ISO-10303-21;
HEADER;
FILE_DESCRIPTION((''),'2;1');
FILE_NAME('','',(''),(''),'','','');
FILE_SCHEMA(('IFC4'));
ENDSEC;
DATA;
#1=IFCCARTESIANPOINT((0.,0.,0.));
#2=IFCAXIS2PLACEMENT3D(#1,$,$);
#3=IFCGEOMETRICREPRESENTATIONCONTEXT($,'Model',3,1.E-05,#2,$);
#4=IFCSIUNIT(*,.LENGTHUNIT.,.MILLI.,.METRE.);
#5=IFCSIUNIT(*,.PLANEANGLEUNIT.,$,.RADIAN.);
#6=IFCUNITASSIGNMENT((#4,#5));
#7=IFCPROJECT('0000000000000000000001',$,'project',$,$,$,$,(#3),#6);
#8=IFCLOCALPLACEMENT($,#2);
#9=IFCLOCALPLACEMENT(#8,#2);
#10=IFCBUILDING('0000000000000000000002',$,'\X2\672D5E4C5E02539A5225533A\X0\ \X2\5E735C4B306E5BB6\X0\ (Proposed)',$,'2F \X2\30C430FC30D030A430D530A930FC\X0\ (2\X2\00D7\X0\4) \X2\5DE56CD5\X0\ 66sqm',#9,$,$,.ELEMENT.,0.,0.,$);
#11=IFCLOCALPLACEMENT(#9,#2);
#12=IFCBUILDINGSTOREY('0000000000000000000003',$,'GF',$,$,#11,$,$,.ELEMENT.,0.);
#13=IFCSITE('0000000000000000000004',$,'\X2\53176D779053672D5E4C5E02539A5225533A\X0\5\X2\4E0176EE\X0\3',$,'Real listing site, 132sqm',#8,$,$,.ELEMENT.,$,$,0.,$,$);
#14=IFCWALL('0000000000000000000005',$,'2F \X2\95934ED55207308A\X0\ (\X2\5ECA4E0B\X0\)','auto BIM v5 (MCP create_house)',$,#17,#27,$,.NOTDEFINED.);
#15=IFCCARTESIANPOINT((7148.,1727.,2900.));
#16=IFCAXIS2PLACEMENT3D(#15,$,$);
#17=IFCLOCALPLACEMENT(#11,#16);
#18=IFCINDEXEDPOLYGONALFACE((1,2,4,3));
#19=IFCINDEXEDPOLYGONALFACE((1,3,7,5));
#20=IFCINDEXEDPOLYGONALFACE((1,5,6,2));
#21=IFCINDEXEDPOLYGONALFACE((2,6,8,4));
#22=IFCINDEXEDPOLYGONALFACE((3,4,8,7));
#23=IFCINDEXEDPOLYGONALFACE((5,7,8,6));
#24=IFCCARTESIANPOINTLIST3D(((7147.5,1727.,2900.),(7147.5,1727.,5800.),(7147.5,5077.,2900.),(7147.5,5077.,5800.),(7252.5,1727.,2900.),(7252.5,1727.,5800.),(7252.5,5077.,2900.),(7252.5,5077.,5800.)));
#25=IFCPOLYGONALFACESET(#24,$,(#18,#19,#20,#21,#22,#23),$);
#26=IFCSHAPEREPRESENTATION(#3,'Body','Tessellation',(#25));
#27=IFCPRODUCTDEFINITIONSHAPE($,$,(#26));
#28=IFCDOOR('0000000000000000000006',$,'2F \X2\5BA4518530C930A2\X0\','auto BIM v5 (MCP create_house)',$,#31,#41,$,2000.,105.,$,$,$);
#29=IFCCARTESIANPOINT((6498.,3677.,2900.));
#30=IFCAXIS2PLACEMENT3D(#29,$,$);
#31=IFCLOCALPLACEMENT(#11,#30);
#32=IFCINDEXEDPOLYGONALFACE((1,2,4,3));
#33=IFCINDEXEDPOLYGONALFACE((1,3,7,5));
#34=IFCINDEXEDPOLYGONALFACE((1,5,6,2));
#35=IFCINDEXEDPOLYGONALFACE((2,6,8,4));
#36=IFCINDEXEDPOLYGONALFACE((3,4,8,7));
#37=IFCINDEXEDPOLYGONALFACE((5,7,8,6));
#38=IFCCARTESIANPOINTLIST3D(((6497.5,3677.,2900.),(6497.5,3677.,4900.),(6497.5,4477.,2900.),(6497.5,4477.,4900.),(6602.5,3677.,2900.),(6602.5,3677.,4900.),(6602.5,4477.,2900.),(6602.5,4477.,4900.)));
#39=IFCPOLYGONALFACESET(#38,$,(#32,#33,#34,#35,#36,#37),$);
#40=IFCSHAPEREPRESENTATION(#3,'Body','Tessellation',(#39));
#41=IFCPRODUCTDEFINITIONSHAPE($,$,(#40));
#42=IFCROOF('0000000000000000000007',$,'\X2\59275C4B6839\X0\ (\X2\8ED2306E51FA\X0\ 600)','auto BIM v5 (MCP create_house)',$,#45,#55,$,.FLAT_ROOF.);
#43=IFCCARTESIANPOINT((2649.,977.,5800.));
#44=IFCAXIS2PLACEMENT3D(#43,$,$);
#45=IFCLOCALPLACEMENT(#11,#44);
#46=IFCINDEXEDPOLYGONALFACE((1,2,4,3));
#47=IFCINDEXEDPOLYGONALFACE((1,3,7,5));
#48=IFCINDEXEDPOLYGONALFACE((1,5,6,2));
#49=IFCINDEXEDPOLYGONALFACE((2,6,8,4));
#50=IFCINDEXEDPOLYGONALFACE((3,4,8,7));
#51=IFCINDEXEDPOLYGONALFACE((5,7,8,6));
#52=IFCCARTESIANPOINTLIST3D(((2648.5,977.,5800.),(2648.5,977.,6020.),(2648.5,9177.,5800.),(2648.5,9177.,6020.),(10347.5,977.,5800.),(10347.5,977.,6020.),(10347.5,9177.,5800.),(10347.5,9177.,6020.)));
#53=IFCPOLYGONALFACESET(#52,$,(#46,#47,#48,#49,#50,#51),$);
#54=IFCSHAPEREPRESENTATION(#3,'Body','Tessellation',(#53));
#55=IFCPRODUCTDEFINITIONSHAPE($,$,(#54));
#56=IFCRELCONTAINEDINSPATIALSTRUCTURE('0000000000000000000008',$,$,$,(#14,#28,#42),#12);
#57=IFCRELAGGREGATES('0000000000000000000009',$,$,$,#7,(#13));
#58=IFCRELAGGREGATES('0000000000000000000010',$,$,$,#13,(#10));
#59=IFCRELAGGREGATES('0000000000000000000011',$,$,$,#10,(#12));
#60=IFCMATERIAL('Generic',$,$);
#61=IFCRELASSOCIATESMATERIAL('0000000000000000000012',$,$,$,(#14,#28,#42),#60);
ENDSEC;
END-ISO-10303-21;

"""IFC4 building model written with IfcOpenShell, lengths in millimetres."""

from ifc_helpers import new_model, si_unit, frame, frame_2d, origin, place, context, project, spatial, rectangle, extrude, material, element, save


model = new_model("IFC4")

# Units and contexts
model_context = context("Model", 3, precision=1e-05, world=origin())
ifc_project = project(units=[si_unit("LENGTHUNIT", "METRE", prefix="MILLI"), si_unit("PLANEANGLEUNIT", "RADIAN")], contexts=[model_context])

# Site, building, storey
site_placement = place(None, origin())
site = spatial("IfcSite", under=ifc_project, at=site_placement, Name="北海道札幌市厚別区5丁目3", ObjectType="Real listing site, 132sqm", CompositionType="ELEMENT", RefElevation=0.0)
building_placement = place(site_placement, origin())
building = spatial("IfcBuilding", under=site, at=building_placement, Name="札幌市厚別区 平屋の家 (Proposed)", ObjectType="2F ツーバイフォー (2×4) 工法 66sqm", CompositionType="ELEMENT", ElevationOfRefHeight=0.0, ElevationOfTerrain=0.0)
storey_placement = place(building_placement, origin())
storey = spatial("IfcBuildingStorey", under=building, at=storey_placement, Name="GF", CompositionType="ELEMENT", Elevation=0.0)

# Shared definitions
ifc_material = material(Name="Generic")

# Wall
wall_1_placement = place(storey_placement, frame((7148.0, 1727.0, 2900.0)))
element("IfcWall", 1, at=wall_1_placement, inside=storey, material=ifc_material, Name="2F 間仕切り (廊下)", Description="auto BIM v5 (MCP create_house)", PredefinedType="NOTDEFINED", context=model_context, shape_type="SweptSolid", body=[
    extrude(rectangle(XDim=105.0, YDim=3350.0, at=frame_2d((52.0, 1675.0))), frame((7148.0, 1727.0, 2900.0)), (0.0, 0.0, 1.0), 2900.0),
])

# Door
door_1_placement = place(storey_placement, frame((6498.0, 3677.0, 2900.0)))
element("IfcDoor", 2, at=door_1_placement, inside=storey, material=ifc_material, Name="2F 室内ドア", Description="auto BIM v5 (MCP create_house)", OverallHeight=2000.0, OverallWidth=105.0, context=model_context, shape_type="SweptSolid", body=[
    extrude(rectangle(XDim=105.0, YDim=800.0, at=frame_2d((52.0, 400.0))), frame((6498.0, 3677.0, 2900.0)), (0.0, 0.0, 1.0), 2000.0),
])

# Roof
roof_placement = place(storey_placement, frame((2649.0, 977.0, 5800.0)))
element("IfcRoof", 3, at=roof_placement, inside=storey, material=ifc_material, Name="大屋根 (軒の出 600)", Description="auto BIM v5 (MCP create_house)", PredefinedType="FLAT_ROOF", context=model_context, shape_type="SweptSolid", body=[
    extrude(rectangle(XDim=7699.0, YDim=8200.0, at=frame_2d((3849.0, 4100.0))), frame((2649.0, 977.0, 5800.0)), (0.0, 0.0, 1.0), 220.0),
])

save(model, "model.ifc")
